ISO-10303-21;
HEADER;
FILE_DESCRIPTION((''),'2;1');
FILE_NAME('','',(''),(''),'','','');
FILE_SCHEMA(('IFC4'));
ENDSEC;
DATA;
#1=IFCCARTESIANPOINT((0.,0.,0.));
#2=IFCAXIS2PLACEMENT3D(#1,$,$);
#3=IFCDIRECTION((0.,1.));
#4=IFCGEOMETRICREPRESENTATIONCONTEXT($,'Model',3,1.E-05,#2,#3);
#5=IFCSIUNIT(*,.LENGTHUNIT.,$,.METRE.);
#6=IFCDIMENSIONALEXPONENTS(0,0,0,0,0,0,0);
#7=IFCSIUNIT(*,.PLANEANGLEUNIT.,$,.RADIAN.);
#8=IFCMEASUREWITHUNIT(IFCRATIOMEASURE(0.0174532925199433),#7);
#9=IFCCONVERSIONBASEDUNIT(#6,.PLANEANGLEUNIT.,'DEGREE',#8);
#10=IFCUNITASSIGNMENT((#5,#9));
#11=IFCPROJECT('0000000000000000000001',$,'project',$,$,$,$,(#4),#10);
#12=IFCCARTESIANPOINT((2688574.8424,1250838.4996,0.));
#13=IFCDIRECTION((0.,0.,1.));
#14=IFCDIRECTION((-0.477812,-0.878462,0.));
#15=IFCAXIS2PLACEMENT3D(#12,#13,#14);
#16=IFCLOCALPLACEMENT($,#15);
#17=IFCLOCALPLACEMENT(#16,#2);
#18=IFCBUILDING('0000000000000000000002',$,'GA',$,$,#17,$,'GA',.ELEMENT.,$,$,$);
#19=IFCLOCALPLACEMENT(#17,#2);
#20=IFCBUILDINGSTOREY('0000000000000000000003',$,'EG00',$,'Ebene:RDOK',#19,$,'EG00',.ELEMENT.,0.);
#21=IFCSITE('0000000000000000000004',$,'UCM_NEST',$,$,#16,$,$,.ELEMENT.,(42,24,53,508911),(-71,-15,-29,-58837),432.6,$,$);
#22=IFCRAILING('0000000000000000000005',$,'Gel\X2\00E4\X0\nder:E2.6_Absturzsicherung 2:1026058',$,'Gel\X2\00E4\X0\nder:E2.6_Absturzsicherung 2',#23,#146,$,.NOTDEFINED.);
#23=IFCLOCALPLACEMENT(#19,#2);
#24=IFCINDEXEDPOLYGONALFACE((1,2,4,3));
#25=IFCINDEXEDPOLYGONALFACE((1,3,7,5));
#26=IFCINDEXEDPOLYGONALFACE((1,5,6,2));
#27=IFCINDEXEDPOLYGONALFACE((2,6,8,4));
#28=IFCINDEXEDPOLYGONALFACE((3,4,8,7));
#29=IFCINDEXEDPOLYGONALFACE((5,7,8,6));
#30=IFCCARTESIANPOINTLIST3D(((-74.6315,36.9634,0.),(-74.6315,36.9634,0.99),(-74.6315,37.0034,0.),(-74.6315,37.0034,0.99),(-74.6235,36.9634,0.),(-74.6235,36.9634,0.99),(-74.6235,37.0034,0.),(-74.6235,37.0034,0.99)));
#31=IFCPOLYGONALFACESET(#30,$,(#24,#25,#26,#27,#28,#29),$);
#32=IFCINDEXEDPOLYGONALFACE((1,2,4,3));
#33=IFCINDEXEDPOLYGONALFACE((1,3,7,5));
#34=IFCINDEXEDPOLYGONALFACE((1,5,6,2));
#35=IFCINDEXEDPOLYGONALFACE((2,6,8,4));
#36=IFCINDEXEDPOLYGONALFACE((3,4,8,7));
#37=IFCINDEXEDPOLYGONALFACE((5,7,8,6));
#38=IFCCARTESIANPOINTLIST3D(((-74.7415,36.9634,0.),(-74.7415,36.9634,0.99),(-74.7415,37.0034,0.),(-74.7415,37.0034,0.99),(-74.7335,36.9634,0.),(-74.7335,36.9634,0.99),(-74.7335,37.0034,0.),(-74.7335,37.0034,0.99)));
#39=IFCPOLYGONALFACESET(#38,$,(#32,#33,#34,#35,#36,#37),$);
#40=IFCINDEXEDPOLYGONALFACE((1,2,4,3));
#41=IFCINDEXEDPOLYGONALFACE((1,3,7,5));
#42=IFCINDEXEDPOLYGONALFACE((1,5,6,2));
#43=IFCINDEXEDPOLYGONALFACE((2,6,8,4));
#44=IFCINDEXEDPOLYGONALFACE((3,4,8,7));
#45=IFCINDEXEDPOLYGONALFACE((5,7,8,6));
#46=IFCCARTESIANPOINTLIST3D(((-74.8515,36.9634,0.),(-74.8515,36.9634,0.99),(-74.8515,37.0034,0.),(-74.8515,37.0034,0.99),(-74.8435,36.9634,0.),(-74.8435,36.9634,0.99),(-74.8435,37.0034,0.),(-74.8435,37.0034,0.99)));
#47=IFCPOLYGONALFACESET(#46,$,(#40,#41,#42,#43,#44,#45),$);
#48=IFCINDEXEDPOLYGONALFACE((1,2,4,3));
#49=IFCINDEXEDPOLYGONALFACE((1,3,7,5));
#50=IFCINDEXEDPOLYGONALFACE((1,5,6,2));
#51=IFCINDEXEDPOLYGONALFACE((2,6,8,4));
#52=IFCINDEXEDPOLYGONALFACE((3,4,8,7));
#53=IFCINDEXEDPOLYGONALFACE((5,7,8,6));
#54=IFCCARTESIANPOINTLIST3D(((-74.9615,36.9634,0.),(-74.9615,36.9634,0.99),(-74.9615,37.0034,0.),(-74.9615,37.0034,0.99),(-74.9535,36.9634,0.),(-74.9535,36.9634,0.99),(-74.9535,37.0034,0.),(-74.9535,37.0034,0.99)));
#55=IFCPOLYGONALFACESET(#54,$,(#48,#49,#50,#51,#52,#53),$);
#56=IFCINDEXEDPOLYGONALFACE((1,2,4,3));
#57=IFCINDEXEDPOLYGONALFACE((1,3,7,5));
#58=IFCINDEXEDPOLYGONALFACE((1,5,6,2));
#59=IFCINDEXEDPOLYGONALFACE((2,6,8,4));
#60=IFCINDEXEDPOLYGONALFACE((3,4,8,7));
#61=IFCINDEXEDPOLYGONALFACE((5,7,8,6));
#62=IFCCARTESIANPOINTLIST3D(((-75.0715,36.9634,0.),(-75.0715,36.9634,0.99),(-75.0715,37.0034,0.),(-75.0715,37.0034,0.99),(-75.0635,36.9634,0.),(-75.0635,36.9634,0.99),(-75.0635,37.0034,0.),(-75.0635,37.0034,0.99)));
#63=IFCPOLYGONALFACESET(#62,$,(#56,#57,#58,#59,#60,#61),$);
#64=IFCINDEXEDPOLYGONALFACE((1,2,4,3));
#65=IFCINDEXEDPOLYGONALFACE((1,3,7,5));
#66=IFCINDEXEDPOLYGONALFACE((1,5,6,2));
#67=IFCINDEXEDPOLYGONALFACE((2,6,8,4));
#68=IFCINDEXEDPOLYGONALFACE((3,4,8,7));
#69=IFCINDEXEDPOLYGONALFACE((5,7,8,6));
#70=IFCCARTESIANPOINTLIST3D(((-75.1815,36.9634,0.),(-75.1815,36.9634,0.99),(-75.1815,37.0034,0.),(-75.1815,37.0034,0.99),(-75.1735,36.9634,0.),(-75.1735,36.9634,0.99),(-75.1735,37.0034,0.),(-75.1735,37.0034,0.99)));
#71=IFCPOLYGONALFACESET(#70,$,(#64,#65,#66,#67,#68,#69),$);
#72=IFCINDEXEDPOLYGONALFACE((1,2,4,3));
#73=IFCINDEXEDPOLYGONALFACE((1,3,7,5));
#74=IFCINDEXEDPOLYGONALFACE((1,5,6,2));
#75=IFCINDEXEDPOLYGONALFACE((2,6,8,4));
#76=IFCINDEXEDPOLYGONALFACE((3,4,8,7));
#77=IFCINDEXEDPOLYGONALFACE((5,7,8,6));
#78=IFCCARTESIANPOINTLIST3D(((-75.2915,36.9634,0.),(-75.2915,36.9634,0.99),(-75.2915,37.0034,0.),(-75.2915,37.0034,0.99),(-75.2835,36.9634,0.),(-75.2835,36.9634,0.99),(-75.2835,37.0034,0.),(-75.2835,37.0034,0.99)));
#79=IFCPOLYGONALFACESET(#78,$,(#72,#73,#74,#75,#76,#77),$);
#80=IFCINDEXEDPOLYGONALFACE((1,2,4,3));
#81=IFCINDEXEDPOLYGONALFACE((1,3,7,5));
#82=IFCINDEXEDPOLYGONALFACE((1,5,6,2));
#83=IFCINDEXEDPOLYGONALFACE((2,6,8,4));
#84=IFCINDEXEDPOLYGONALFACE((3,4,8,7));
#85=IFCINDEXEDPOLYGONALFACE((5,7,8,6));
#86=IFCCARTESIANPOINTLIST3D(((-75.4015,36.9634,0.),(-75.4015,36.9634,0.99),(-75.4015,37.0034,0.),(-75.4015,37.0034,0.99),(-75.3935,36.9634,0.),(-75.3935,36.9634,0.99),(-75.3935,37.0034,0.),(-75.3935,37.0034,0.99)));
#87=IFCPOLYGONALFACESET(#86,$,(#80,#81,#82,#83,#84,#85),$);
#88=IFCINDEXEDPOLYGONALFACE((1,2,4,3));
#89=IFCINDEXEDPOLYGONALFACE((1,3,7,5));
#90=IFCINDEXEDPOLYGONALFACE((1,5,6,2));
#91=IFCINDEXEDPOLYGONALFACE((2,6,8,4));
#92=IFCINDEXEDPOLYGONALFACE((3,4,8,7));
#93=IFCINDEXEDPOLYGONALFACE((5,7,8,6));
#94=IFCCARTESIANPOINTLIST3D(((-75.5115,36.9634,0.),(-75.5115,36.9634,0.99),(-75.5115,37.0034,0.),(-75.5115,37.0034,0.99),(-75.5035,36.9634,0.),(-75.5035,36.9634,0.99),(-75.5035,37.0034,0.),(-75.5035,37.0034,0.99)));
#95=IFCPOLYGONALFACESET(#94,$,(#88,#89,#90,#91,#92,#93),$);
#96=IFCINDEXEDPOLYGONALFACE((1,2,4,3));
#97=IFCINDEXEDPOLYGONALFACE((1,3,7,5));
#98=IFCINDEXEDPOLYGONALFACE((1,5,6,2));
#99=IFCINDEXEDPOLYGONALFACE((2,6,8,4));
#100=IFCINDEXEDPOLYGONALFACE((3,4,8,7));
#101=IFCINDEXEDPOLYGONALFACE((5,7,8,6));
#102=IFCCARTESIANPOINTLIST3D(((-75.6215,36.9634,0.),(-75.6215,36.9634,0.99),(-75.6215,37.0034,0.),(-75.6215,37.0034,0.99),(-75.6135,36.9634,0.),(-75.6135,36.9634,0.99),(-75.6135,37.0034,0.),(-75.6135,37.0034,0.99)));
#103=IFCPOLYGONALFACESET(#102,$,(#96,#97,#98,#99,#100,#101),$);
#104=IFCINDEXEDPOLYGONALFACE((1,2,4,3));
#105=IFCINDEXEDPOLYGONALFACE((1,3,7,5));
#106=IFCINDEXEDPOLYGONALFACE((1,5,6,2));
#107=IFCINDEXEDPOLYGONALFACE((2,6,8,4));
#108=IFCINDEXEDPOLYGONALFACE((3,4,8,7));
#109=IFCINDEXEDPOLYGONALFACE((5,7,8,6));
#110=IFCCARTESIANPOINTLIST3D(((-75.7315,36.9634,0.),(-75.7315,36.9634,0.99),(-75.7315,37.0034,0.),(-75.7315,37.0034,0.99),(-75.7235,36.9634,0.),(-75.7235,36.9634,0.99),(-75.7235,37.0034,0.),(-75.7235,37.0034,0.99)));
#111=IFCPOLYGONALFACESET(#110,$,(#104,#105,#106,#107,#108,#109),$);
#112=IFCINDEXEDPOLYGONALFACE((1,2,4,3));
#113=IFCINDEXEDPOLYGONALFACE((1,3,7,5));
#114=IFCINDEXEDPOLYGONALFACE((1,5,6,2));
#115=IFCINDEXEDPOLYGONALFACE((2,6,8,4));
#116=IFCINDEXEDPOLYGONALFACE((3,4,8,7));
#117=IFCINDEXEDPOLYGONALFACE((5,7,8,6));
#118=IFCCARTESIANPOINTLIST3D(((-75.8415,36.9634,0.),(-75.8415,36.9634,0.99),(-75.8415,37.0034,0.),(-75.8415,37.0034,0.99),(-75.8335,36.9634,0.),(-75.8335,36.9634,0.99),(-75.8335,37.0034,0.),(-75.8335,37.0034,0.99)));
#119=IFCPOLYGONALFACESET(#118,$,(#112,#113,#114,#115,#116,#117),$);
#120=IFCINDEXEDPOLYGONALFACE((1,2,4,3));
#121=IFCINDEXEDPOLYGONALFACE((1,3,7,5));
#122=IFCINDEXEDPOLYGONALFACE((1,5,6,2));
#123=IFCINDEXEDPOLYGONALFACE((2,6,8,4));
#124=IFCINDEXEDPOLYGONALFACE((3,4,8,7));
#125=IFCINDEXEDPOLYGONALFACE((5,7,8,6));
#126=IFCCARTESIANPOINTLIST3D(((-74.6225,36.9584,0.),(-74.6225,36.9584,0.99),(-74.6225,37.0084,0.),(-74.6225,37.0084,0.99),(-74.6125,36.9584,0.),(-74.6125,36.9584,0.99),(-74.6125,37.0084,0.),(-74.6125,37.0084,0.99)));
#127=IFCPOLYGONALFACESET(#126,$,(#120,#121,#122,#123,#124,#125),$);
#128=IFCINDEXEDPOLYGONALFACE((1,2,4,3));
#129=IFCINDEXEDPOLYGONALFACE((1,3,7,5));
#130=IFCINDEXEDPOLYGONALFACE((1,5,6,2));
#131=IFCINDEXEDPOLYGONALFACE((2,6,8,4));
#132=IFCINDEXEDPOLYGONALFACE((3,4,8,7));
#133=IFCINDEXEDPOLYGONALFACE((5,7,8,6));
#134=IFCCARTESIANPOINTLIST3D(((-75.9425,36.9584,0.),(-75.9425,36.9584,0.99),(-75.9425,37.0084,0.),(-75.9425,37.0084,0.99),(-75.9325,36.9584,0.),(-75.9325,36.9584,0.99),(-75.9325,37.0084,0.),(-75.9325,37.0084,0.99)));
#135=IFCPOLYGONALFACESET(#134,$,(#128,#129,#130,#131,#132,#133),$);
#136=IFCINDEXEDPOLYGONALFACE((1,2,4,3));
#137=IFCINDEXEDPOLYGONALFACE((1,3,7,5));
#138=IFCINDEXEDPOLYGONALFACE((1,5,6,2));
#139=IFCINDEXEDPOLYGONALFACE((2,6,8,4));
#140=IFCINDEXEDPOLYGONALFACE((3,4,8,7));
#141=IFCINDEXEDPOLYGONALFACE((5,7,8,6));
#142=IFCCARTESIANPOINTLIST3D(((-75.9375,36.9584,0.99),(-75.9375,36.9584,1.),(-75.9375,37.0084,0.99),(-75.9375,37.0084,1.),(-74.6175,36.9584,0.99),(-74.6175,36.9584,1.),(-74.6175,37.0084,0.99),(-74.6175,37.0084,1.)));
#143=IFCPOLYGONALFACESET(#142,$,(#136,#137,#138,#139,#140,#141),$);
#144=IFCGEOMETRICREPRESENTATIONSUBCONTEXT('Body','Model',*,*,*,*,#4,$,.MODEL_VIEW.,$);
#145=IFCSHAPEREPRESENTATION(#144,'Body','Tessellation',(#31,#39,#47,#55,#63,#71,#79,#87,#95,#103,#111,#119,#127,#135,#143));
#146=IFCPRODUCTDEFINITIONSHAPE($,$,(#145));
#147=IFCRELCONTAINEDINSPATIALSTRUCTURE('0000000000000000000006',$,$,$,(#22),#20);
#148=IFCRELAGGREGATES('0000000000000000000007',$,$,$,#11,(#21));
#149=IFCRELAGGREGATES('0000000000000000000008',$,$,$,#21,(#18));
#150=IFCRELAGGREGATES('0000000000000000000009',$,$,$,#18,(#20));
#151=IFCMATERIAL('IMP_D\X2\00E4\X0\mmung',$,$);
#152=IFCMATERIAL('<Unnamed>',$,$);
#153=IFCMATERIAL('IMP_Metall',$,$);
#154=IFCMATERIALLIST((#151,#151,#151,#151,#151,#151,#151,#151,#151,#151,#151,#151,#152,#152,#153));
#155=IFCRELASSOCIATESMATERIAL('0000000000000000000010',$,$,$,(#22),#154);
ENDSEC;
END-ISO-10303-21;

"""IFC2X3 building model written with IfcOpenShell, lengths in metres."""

from ifc_helpers import new_model, entity, si_unit, converted_unit, direction, frame, frame_2d, origin, origin_2d_with_axis, place, context, subcontext, project, spatial, rectangle, extrude, material, material_list, element, save


model = new_model("IFC2X3")

# Units and contexts
model_context = context("Model", 3, precision=1e-05, world=origin(), true_north=direction((0.0, 1.0)))
body_context = subcontext(model_context, "Body", "Model", "MODEL_VIEW")
ifc_project = project(units=[si_unit("LENGTHUNIT", "METRE"), converted_unit("PLANEANGLEUNIT", "DEGREE", entity("IfcRatioMeasure", 0.0174532925199433), si_unit("PLANEANGLEUNIT", "RADIAN"), dimensions=[0, 0, 0, 0, 0, 0, 0])], contexts=[model_context])

# Site, building, storey
site_placement = place(None, frame((2688574.8424, 1250838.4996, 0.0), z_axis=(0.0, 0.0, 1.0), x_axis=(-0.477812, -0.878462, 0.0)))
site = spatial("IfcSite", under=ifc_project, at=site_placement, Name="UCM_NEST", CompositionType="ELEMENT", RefLatitude=(42, 24, 53, 508911), RefLongitude=(-71, -15, -29, -58837), RefElevation=432.6)
building_placement = place(site_placement, origin())
building = spatial("IfcBuilding", under=site, at=building_placement, Name="GA", LongName="GA", CompositionType="ELEMENT")
storey_placement = place(building_placement, origin())
storey = spatial("IfcBuildingStorey", under=building, at=storey_placement, Name="EG00", ObjectType="Ebene:RDOK", LongName="EG00", CompositionType="ELEMENT", Elevation=0.0)

# Shared definitions
ifc_material_1 = material(Name="IMP_Dämmung")

# Railing
ifc_material_2 = material(Name="<Unnamed>")
ifc_material_3 = material(Name="IMP_Metall")
ifc_material_list_1 = material_list([ifc_material_1, ifc_material_1, ifc_material_1, ifc_material_1, ifc_material_1, ifc_material_1, ifc_material_1, ifc_material_1, ifc_material_1, ifc_material_1, ifc_material_1, ifc_material_1, ifc_material_2, ifc_material_2, ifc_material_3])
railing_1_placement = place(storey_placement, origin())
element("IfcRailing", 1, at=railing_1_placement, inside=storey, material=ifc_material_list_1, Name="Geländer:E2.6_Absturzsicherung 2:1026058", ObjectType="Geländer:E2.6_Absturzsicherung 2", PredefinedType="NOTDEFINED", context=body_context, shape_type="SweptSolid", body=[
    extrude(rectangle(XDim=0.008, YDim=0.04, at=origin_2d_with_axis()), frame((-74.6275, 36.9834, 0.0)), (0.0, 0.0, 1.0), 0.99),
    extrude(rectangle(XDim=0.008, YDim=0.04, at=origin_2d_with_axis()), frame((-74.7375, 36.9834, 0.0)), (0.0, 0.0, 1.0), 0.99),
    extrude(rectangle(XDim=0.008, YDim=0.04, at=origin_2d_with_axis()), frame((-74.8475, 36.9834, 0.0)), (0.0, 0.0, 1.0), 0.99),
    extrude(rectangle(XDim=0.008, YDim=0.04, at=origin_2d_with_axis()), frame((-74.9575, 36.9834, 0.0)), (0.0, 0.0, 1.0), 0.99),
    extrude(rectangle(XDim=0.008, YDim=0.04, at=origin_2d_with_axis()), frame((-75.0675, 36.9834, 0.0)), (0.0, 0.0, 1.0), 0.99),
    extrude(rectangle(XDim=0.008, YDim=0.04, at=origin_2d_with_axis()), frame((-75.1775, 36.9834, 0.0)), (0.0, 0.0, 1.0), 0.99),
    extrude(rectangle(XDim=0.008, YDim=0.04, at=origin_2d_with_axis()), frame((-75.2875, 36.9834, 0.0)), (0.0, 0.0, 1.0), 0.99),
    extrude(rectangle(XDim=0.008, YDim=0.04, at=origin_2d_with_axis()), frame((-75.3975, 36.9834, 0.0)), (0.0, 0.0, 1.0), 0.99),
    extrude(rectangle(XDim=0.008, YDim=0.04, at=origin_2d_with_axis()), frame((-75.5075, 36.9834, 0.0)), (0.0, 0.0, 1.0), 0.99),
    extrude(rectangle(XDim=0.008, YDim=0.04, at=origin_2d_with_axis()), frame((-75.6175, 36.9834, 0.0)), (0.0, 0.0, 1.0), 0.99),
    extrude(rectangle(XDim=0.008, YDim=0.04, at=origin_2d_with_axis()), frame((-75.7275, 36.9834, 0.0)), (0.0, 0.0, 1.0), 0.99),
    extrude(rectangle(XDim=0.008, YDim=0.04, at=origin_2d_with_axis()), frame((-75.8375, 36.9834, 0.0)), (0.0, 0.0, 1.0), 0.99),
    extrude(rectangle(XDim=0.01, YDim=0.05, at=frame_2d((0.0, 0.0), x_axis=(1.0, 0.0))), frame((-74.6175, 36.9834, 0.0)), (0.0, 0.0, 1.0), 0.99),
    extrude(rectangle(XDim=0.01, YDim=0.05, at=frame_2d((0.0, 0.0), x_axis=(1.0, 0.0))), frame((-75.9375, 36.9834, 0.0)), (0.0, 0.0, 1.0), 0.99),
    extrude(rectangle(XDim=1.32, YDim=0.05, at=origin_2d_with_axis()), frame((-75.2775, 36.9834, 0.99)), (0.0, 0.0, 1.0), 0.01),
])

save(model, "model.ifc")
